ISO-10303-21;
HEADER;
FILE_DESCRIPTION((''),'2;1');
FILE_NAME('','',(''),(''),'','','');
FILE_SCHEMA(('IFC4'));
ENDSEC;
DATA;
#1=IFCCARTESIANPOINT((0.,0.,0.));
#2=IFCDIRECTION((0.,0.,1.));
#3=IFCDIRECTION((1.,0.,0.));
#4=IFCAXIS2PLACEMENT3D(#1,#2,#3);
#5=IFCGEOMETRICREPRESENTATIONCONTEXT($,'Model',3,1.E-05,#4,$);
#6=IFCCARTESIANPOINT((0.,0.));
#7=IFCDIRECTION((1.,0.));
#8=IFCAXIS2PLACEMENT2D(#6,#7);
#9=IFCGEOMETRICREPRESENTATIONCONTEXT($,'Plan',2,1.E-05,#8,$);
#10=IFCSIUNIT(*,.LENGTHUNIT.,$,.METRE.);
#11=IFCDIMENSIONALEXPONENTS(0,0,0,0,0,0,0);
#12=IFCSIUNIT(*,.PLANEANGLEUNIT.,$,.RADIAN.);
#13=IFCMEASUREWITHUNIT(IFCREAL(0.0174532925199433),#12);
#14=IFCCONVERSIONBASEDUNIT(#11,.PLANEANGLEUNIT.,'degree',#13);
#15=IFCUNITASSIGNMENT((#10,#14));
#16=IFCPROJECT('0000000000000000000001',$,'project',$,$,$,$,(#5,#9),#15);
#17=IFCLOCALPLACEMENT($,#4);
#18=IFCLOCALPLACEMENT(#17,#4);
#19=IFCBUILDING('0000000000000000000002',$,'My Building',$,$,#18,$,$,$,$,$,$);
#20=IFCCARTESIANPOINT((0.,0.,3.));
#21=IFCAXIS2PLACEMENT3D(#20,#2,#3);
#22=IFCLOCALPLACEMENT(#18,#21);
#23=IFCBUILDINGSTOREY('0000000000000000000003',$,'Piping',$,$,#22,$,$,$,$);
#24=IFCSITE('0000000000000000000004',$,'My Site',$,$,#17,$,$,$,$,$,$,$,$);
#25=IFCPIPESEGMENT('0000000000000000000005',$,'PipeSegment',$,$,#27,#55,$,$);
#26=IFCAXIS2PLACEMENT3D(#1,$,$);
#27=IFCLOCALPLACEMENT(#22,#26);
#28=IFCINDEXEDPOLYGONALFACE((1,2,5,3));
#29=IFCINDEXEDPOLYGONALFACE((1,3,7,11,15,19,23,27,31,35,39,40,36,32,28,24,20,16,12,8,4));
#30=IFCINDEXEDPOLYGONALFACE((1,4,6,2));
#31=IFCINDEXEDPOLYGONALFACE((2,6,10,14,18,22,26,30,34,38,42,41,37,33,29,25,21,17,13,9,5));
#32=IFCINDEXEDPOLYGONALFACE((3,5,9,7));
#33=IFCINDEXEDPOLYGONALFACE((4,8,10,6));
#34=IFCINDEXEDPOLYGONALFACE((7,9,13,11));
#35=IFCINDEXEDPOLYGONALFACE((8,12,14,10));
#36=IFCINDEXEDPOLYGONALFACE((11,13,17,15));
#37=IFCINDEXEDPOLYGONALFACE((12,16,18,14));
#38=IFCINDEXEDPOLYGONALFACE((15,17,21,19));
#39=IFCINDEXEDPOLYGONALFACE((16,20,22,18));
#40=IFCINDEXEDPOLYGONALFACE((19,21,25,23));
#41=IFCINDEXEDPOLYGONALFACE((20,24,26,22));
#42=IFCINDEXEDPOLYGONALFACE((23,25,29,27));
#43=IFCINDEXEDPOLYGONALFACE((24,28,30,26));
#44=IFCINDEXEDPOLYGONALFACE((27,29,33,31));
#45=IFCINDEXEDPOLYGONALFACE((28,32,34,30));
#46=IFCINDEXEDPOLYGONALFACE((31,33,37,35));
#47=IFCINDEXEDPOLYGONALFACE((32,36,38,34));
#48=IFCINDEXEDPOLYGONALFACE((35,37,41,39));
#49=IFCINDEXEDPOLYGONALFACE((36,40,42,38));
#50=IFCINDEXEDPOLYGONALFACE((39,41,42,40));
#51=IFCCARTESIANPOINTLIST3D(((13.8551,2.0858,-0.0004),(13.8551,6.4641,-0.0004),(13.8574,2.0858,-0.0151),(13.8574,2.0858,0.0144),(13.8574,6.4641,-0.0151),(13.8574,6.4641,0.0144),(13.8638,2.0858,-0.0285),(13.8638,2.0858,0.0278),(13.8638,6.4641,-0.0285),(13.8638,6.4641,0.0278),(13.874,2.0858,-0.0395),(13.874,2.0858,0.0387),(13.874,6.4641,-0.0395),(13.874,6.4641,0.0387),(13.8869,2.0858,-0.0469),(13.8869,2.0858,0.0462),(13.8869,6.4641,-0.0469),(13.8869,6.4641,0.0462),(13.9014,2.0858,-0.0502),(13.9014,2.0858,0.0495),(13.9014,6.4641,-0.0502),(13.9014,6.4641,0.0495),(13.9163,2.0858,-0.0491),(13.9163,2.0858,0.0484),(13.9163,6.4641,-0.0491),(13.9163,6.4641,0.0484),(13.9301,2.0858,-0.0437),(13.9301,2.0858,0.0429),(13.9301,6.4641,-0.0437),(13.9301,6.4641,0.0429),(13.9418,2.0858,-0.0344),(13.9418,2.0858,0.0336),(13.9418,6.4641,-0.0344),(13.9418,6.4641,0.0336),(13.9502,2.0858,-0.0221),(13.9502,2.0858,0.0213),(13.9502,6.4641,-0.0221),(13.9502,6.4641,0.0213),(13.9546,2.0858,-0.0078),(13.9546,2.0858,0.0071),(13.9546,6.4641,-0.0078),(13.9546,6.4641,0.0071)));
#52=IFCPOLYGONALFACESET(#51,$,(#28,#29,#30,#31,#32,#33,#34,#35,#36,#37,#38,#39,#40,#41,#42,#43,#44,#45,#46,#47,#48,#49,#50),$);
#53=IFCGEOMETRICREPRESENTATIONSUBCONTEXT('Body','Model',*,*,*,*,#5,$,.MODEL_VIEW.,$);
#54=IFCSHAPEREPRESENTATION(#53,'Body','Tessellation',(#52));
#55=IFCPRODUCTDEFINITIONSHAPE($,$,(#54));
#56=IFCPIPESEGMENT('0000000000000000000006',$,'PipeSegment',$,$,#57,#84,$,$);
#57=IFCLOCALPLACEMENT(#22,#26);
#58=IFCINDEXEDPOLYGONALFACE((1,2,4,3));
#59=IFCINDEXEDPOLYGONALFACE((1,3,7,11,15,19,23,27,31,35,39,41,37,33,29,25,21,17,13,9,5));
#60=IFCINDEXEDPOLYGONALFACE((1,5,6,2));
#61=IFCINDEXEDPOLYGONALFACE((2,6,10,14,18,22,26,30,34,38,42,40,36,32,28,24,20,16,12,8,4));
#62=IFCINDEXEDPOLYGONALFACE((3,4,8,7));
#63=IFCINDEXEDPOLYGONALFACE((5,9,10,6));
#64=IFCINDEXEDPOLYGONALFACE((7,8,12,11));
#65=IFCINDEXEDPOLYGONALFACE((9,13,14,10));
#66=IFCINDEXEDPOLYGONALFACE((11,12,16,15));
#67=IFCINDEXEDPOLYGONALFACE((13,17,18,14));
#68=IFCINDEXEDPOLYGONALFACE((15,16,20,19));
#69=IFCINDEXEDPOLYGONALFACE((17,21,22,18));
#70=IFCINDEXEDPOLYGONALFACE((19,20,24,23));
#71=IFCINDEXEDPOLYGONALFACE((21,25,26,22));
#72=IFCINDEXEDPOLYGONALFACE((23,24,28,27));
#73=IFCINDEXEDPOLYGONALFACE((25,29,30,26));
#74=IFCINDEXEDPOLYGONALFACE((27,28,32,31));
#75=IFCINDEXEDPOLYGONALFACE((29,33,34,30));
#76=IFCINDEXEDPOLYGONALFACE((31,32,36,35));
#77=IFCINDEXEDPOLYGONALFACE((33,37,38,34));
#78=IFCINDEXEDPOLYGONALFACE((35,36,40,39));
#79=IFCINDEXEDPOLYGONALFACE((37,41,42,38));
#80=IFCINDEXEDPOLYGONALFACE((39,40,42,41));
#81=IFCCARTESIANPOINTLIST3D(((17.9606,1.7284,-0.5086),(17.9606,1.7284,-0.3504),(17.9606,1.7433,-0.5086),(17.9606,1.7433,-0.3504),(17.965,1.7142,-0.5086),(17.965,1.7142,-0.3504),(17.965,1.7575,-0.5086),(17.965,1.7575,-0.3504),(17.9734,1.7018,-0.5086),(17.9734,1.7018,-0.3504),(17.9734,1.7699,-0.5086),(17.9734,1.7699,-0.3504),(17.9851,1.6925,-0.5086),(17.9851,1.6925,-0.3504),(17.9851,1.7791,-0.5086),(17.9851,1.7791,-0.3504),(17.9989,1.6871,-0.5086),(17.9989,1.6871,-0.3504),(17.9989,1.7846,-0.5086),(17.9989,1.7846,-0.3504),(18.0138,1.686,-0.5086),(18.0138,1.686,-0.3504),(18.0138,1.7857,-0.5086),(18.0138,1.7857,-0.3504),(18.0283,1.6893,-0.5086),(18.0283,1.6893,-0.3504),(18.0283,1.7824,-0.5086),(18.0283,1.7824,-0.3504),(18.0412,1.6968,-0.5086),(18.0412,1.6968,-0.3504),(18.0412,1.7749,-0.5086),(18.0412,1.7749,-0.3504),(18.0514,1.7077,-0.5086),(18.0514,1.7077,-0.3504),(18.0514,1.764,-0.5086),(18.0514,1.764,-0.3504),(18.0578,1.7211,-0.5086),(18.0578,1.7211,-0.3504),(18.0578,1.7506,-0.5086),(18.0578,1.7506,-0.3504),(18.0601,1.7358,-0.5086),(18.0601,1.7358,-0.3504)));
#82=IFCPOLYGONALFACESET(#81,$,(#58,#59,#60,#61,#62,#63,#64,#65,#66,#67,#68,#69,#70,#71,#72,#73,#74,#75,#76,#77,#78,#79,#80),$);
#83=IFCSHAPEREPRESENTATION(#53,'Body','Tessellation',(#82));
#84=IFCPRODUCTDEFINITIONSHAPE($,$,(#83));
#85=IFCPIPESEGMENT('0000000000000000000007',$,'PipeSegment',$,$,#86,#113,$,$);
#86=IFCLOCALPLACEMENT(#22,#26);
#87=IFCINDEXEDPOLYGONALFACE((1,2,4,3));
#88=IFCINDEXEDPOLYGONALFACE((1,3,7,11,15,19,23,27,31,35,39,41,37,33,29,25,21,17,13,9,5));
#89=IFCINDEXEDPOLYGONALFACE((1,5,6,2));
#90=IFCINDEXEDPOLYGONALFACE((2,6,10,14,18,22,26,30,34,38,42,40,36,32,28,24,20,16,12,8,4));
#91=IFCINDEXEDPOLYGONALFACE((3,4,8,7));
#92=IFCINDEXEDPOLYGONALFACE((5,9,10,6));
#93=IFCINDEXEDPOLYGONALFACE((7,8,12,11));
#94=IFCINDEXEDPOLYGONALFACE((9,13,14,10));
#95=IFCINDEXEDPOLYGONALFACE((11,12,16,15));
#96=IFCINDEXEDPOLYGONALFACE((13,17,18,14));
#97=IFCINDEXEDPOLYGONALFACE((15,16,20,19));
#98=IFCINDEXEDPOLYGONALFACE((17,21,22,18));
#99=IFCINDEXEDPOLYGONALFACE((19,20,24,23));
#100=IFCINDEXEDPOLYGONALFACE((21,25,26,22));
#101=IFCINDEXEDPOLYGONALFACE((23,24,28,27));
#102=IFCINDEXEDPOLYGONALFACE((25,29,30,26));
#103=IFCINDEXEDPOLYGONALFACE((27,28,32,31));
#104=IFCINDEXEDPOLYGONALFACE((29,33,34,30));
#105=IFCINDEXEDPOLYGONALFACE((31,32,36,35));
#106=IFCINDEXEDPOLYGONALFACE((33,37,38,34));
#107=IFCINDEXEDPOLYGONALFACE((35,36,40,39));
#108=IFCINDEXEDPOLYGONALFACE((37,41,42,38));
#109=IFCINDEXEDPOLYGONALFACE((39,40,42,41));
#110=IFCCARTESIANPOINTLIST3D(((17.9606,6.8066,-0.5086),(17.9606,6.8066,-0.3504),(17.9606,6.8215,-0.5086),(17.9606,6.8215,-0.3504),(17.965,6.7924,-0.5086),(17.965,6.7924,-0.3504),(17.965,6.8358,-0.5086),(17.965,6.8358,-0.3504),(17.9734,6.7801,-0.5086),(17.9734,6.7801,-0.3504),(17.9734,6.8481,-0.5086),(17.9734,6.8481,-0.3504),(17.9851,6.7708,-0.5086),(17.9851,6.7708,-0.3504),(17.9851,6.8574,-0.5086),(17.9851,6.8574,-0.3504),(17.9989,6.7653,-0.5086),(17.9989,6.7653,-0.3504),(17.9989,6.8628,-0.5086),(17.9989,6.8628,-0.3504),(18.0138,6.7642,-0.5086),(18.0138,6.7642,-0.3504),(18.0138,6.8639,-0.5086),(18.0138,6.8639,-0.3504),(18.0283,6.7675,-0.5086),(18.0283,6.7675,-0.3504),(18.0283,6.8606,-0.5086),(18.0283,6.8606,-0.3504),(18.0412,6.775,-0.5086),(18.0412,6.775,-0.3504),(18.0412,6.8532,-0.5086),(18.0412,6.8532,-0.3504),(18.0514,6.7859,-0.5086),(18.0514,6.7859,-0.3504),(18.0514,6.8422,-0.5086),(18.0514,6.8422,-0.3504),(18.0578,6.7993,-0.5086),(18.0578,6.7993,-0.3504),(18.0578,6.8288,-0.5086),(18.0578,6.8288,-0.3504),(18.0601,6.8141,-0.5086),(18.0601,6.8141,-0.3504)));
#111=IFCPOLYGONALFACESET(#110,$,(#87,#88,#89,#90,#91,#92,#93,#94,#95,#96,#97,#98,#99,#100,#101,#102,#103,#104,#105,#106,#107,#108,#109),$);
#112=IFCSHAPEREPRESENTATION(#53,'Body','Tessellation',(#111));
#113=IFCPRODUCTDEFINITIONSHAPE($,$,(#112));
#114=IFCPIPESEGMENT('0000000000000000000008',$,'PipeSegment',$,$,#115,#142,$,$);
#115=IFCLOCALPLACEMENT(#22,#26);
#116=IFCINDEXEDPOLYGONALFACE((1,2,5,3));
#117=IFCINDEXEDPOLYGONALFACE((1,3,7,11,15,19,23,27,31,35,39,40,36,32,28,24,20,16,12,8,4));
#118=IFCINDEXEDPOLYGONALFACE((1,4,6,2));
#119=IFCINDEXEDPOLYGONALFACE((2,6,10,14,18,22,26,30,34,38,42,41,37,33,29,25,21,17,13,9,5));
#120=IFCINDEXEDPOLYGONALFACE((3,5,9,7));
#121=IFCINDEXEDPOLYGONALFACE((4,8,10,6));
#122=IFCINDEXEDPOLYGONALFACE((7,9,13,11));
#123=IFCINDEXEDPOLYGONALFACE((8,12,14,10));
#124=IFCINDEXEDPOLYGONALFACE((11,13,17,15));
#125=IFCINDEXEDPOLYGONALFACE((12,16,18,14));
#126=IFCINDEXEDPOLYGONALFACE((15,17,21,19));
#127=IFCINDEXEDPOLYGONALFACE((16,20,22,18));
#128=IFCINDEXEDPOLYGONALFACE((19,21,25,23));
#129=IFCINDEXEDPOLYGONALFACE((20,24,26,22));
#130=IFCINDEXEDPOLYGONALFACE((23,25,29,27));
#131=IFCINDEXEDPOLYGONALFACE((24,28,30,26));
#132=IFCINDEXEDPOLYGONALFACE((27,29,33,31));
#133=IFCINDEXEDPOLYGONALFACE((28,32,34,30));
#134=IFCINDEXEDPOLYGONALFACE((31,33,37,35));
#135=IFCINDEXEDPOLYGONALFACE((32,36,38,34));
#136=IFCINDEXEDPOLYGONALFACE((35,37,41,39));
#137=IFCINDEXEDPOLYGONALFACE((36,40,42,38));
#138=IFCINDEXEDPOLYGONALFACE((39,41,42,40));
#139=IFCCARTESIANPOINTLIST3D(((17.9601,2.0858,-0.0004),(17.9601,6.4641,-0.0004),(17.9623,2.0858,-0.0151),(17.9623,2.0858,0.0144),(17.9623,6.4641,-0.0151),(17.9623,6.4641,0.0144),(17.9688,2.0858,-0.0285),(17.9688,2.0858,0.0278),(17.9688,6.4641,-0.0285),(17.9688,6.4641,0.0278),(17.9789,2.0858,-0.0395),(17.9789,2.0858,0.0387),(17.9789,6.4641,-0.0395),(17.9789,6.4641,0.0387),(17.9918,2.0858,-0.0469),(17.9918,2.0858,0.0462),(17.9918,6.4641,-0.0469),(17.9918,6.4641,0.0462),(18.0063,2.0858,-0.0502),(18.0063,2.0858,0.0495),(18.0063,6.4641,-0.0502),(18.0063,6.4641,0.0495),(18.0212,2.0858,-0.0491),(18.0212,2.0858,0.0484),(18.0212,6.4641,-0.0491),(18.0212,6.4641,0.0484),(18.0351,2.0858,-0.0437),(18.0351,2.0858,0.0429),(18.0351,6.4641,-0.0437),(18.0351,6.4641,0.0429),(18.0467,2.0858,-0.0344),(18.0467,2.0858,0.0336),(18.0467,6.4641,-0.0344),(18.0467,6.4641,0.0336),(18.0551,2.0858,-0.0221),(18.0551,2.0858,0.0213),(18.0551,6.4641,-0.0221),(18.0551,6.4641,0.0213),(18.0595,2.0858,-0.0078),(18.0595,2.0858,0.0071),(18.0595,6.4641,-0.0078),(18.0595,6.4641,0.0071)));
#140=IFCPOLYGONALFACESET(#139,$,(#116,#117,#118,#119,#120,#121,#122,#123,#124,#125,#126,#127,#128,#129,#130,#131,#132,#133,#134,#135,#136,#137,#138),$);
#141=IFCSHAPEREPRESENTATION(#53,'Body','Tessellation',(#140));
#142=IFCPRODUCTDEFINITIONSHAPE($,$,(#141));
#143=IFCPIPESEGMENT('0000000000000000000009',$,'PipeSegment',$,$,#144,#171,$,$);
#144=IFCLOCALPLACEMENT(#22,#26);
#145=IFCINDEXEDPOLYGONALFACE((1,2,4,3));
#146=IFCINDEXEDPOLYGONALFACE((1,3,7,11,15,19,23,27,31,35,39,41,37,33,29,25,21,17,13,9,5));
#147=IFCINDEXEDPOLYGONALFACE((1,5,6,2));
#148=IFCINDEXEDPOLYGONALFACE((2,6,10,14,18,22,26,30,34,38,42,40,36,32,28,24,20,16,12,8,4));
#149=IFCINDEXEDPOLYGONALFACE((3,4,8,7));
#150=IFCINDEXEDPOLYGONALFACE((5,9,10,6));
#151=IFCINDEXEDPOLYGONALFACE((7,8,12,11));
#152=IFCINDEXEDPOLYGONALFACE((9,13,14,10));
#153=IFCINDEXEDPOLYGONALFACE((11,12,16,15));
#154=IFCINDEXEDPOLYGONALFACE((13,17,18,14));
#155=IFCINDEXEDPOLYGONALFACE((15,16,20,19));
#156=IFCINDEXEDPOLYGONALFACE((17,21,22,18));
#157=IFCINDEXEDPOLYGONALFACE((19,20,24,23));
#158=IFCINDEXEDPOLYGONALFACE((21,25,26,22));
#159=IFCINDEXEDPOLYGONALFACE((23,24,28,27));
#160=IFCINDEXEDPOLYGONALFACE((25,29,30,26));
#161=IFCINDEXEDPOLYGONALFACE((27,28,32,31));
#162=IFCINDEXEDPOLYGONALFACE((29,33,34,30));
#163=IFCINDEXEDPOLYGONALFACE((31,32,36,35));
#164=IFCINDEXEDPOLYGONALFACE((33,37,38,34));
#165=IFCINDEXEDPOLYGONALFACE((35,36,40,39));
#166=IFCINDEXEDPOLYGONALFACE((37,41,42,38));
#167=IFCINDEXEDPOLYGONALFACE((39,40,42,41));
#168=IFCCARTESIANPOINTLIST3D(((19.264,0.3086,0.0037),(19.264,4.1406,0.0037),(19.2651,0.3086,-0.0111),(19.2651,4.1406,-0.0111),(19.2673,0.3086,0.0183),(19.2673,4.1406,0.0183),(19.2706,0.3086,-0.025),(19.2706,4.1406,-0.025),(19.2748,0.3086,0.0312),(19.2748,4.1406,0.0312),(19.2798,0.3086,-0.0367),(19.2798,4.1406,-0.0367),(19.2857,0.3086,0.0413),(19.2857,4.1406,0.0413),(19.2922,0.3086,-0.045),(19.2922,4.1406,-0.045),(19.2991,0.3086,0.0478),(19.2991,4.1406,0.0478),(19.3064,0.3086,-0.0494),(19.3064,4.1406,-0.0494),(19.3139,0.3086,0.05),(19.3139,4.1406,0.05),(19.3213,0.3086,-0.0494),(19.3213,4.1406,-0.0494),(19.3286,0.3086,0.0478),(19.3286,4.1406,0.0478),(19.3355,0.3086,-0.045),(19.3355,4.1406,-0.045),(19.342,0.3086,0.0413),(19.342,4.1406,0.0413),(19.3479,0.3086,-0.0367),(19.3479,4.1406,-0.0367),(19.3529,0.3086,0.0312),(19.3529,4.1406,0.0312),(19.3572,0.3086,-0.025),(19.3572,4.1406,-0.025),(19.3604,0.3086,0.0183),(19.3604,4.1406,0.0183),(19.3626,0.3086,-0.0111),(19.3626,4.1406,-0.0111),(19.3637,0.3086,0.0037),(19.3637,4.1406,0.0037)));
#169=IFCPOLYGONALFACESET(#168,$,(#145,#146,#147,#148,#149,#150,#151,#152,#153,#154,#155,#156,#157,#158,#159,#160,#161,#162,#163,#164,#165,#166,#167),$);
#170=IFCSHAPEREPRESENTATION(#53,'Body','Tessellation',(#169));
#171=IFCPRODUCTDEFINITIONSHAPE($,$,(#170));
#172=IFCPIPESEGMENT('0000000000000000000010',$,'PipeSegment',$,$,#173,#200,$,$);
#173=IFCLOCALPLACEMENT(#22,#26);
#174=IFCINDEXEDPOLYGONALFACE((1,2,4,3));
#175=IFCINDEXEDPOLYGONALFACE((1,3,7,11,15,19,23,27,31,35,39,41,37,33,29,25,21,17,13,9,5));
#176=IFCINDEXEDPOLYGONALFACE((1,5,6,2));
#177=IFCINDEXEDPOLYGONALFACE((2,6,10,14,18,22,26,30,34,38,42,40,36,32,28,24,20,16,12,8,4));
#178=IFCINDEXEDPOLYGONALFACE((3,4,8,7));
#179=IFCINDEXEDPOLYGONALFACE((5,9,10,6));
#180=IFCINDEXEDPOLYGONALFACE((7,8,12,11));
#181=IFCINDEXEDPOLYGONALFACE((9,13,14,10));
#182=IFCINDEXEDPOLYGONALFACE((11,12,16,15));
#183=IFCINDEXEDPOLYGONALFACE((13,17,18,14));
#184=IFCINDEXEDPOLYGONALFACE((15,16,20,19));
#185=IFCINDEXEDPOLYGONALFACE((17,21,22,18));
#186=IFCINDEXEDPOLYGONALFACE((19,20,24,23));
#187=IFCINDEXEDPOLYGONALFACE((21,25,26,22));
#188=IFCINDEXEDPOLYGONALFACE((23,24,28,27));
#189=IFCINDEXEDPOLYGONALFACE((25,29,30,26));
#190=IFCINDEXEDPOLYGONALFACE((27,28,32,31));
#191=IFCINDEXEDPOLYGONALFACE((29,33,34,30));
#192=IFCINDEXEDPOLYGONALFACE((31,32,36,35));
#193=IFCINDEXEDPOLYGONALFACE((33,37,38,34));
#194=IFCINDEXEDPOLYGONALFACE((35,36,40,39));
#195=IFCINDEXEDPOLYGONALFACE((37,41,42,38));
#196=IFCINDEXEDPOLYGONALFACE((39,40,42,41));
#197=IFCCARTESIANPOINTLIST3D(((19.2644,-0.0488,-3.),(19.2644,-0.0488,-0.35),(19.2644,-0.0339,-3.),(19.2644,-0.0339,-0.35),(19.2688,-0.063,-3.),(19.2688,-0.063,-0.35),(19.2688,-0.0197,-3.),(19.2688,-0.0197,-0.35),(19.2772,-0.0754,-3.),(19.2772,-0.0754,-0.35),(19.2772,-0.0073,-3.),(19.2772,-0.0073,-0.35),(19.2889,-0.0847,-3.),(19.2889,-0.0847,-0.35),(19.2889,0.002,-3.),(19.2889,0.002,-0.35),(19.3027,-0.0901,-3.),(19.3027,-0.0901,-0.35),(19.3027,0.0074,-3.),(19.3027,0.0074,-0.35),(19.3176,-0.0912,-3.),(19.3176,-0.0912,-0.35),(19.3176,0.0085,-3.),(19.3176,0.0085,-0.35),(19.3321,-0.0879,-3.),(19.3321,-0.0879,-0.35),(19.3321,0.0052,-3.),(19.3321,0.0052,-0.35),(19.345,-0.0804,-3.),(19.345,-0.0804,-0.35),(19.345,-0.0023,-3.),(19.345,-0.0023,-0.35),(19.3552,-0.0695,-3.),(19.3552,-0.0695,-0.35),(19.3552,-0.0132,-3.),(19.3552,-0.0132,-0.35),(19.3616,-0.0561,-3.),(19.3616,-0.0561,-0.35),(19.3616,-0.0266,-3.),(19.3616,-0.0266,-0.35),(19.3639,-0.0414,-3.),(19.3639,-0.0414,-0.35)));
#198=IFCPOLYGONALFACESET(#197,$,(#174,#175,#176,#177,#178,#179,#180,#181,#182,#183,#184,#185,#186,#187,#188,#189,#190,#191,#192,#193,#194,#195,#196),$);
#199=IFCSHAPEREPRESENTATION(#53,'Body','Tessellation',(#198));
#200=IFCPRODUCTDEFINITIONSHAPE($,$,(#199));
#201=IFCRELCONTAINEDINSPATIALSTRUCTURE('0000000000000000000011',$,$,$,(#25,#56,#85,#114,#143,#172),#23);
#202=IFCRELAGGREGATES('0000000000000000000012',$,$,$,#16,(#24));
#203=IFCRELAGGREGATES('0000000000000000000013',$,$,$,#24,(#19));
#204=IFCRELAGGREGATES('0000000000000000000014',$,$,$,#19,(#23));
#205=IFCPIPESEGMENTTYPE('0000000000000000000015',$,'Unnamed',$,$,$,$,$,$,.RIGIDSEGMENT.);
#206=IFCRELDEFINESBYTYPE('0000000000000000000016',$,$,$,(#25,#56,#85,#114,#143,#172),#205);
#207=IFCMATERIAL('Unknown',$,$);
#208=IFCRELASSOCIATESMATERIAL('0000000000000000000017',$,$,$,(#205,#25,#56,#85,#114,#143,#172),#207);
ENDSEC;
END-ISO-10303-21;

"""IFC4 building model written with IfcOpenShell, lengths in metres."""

from ifc_helpers import new_model, entity, si_unit, converted_unit, frame, origin_with_axes, origin_2d_with_axis, place, context, subcontext, project, spatial, circle, extrude, material, material_profile, profile_set, profile_usage, type_object, element, save


model = new_model("IFC4")

# Units and contexts
model_context = context("Model", 3, precision=1e-05, world=origin_with_axes())
plan_context = context("Plan", 2, precision=1e-05, world=origin_2d_with_axis())
body_context = subcontext(model_context, "Body", "Model", "MODEL_VIEW")
ifc_project = project(units=[si_unit("LENGTHUNIT", "METRE"), converted_unit("PLANEANGLEUNIT", "degree", entity("IfcReal", 0.0174532925199433), si_unit("PLANEANGLEUNIT", "RADIAN"), dimensions=[0, 0, 0, 0, 0, 0, 0])], contexts=[model_context, plan_context])

# Site, building, storey
site_placement = place(None, origin_with_axes())
site = spatial("IfcSite", under=ifc_project, at=site_placement, Name="My Site")
building_placement = place(site_placement, origin_with_axes())
building = spatial("IfcBuilding", under=site, at=building_placement, Name="My Building")
storey_placement = place(building_placement, frame((0.0, 0.0, 3.0), z_axis=(0.0, 0.0, 1.0), x_axis=(1.0, 0.0, 0.0)))
storey = spatial("IfcBuildingStorey", under=building, at=storey_placement, Name="Piping")

# Pipe segments
ifc_material = material(Name="Unknown")
ifc_material_profile = material_profile(ifc_material, circle(Radius=0.05))
ifc_profile_set = profile_set([ifc_material_profile])
pipe_segment_type = type_object("IfcPipeSegmentType", Name="Unnamed", PredefinedType="RIGIDSEGMENT", material=ifc_profile_set)
ifc_profile_usage_1 = profile_usage(ifc_profile_set, cardinal=5)
pipe_segment_1_placement = place(storey_placement, frame((13.9051, 2.0858, -0.0004), z_axis=(0.0, 1.0, 0.0), x_axis=(-1.0, 0.0, 0.0)))
element("IfcPipeSegment", 1, at=pipe_segment_1_placement, inside=storey, type_object=pipe_segment_type, material=ifc_profile_usage_1, Name="PipeSegment", context=body_context, shape_type="SweptSolid", body=[
    extrude(circle(Radius=0.05), origin_with_axes(), (0.0, 0.0, 1.0), 4.3782),
])
ifc_profile_usage_2 = profile_usage(ifc_profile_set, cardinal=5)
pipe_segment_2_placement = place(storey_placement, frame((18.0101, 1.7358, -0.3504), z_axis=(0.0, 0.0, -1.0), x_axis=(1.0, 0.0, 0.0)))
element("IfcPipeSegment", 2, at=pipe_segment_2_placement, inside=storey, type_object=pipe_segment_type, material=ifc_profile_usage_2, Name="PipeSegment", context=body_context, shape_type="SweptSolid", body=[
    extrude(circle(Radius=0.05), origin_with_axes(), (0.0, 0.0, 1.0), 0.1582),
])
ifc_profile_usage_3 = profile_usage(ifc_profile_set, cardinal=5)
pipe_segment_3_placement = place(storey_placement, frame((18.0101, 6.8141, -0.3504), z_axis=(0.0, 0.0, -1.0), x_axis=(1.0, 0.0, 0.0)))
element("IfcPipeSegment", 3, at=pipe_segment_3_placement, inside=storey, type_object=pipe_segment_type, material=ifc_profile_usage_3, Name="PipeSegment", context=body_context, shape_type="SweptSolid", body=[
    extrude(circle(Radius=0.05), origin_with_axes(), (0.0, 0.0, 1.0), 0.1582),
])
ifc_profile_usage_4 = profile_usage(ifc_profile_set, cardinal=5)
pipe_segment_4_placement = place(storey_placement, frame((18.0101, 2.0858, -0.0004), z_axis=(0.0, 1.0, 0.0), x_axis=(-1.0, 0.0, 0.0)))
element("IfcPipeSegment", 4, at=pipe_segment_4_placement, inside=storey, type_object=pipe_segment_type, material=ifc_profile_usage_4, Name="PipeSegment", context=body_context, shape_type="SweptSolid", body=[
    extrude(circle(Radius=0.05), origin_with_axes(), (0.0, 0.0, 1.0), 4.3782),
])
ifc_profile_usage_5 = profile_usage(ifc_profile_set, cardinal=5)
pipe_segment_5_placement = place(storey_placement, frame((19.3139, 4.1406, 0.0), z_axis=(0.0, -1.0, 0.0), x_axis=(0.0, 0.0, 1.0)))
element("IfcPipeSegment", 5, at=pipe_segment_5_placement, inside=storey, type_object=pipe_segment_type, material=ifc_profile_usage_5, Name="PipeSegment", context=body_context, shape_type="SweptSolid", body=[
    extrude(circle(Radius=0.05), origin_with_axes(), (0.0, 0.0, 1.0), 3.8319),
])
ifc_profile_usage_6 = profile_usage(ifc_profile_set, cardinal=5)
pipe_segment_6_placement = place(storey_placement, frame((19.3139, -0.0414, -0.35), z_axis=(0.0, 0.0, -1.0), x_axis=(1.0, 0.0, 0.0)))
element("IfcPipeSegment", 6, at=pipe_segment_6_placement, inside=storey, type_object=pipe_segment_type, material=ifc_profile_usage_6, Name="PipeSegment", context=body_context, shape_type="SweptSolid", body=[
    extrude(circle(Radius=0.05), origin_with_axes(), (0.0, 0.0, 1.0), 2.65),
])

save(model, "model.ifc")
